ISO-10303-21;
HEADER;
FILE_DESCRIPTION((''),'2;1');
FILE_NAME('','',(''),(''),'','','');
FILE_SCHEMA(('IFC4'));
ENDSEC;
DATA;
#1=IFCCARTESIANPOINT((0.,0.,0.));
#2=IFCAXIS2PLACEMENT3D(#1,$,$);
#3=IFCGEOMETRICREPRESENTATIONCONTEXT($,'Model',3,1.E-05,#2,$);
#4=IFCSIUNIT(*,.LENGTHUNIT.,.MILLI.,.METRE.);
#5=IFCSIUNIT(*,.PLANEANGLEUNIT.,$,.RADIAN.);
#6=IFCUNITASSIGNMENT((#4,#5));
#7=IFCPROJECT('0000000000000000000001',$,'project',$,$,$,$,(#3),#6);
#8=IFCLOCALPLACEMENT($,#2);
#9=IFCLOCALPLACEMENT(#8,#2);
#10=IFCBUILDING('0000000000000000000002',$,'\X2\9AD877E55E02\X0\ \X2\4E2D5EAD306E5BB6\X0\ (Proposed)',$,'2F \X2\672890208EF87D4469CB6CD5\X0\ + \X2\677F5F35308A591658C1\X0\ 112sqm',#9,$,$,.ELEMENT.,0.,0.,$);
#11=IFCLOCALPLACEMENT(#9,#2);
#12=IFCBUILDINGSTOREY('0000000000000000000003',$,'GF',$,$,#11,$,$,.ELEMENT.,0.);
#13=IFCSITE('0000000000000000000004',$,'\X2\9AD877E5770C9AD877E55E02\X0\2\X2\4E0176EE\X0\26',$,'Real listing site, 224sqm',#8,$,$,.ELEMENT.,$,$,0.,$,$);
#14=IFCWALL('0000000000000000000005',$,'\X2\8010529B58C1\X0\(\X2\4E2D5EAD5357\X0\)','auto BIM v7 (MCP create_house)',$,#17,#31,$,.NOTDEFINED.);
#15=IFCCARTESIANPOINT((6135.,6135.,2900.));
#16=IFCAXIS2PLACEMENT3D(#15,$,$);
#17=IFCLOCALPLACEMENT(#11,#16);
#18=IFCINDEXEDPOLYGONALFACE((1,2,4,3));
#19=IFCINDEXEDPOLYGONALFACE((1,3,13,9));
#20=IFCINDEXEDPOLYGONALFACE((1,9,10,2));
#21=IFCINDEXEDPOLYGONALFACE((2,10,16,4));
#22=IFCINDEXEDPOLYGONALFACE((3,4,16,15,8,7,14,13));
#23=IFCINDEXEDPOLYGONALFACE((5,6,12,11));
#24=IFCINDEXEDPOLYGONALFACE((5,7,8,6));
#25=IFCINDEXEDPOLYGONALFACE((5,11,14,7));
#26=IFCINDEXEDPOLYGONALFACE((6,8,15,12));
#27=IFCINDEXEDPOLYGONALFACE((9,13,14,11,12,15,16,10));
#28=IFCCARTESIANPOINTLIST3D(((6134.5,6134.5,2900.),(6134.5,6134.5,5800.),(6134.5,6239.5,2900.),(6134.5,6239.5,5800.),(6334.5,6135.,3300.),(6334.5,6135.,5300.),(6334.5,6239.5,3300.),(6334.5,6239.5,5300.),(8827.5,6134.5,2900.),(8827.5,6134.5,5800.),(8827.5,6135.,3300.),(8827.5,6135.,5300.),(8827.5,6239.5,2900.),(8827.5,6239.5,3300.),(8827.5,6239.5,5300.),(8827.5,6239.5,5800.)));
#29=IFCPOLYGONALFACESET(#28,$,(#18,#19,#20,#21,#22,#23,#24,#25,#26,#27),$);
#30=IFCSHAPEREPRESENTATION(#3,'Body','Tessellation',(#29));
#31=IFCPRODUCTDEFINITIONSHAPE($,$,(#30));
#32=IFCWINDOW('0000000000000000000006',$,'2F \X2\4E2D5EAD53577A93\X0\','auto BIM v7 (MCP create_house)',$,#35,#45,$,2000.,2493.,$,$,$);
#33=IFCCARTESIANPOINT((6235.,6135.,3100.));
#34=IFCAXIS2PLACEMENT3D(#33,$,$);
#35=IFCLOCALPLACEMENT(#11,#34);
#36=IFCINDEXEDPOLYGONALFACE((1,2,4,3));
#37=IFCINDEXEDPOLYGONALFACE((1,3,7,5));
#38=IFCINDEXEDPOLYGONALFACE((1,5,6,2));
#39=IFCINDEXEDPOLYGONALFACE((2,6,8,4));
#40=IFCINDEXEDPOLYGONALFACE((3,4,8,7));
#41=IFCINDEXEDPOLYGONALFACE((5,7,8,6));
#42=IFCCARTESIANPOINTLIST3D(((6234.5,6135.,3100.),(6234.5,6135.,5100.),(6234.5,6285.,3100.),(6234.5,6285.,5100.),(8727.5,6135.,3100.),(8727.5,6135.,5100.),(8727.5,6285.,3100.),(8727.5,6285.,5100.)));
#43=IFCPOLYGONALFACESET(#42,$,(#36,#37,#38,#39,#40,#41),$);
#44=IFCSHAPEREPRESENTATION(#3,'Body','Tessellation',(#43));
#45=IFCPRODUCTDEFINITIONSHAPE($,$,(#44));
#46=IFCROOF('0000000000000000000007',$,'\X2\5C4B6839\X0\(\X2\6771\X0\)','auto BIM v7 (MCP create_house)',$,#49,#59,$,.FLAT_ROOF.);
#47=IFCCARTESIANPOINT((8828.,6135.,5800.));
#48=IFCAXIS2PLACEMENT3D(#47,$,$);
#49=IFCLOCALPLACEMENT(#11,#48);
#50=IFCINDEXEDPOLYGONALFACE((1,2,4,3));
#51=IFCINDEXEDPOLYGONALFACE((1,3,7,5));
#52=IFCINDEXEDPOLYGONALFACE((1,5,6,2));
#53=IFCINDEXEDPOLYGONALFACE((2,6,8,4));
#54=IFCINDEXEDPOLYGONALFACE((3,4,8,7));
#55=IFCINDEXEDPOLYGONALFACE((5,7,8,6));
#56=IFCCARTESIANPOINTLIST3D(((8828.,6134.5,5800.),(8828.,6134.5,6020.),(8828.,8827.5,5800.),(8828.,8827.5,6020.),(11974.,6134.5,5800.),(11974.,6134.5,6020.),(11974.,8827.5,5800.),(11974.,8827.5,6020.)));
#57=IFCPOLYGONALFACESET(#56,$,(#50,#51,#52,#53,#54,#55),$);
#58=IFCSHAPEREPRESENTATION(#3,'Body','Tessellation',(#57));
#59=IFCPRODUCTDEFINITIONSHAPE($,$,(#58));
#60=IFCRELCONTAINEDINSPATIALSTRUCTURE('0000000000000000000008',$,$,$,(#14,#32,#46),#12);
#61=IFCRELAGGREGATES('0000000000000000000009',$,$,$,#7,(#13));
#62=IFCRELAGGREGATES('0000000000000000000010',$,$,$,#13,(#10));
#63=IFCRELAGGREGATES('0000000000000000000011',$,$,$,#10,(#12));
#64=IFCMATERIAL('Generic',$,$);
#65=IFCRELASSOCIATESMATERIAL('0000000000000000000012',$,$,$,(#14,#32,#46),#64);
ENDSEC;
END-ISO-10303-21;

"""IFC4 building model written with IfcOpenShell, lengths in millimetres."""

from ifc_helpers import new_model, si_unit, frame, frame_2d, origin, place, context, project, spatial, rectangle, extrude, material, element, fill, save


model = new_model("IFC4")

# Units and contexts
model_context = context("Model", 3, precision=1e-05, world=origin())
ifc_project = project(units=[si_unit("LENGTHUNIT", "METRE", prefix="MILLI"), si_unit("PLANEANGLEUNIT", "RADIAN")], contexts=[model_context])

# Site, building, storey
site_placement = place(None, origin())
site = spatial("IfcSite", under=ifc_project, at=site_placement, Name="高知県高知市2丁目26", ObjectType="Real listing site, 224sqm", CompositionType="ELEMENT", RefElevation=0.0)
building_placement = place(site_placement, origin())
building = spatial("IfcBuilding", under=site, at=building_placement, Name="高知市 中庭の家 (Proposed)", ObjectType="2F 木造軸組構法 + 板張り外壁 112sqm", CompositionType="ELEMENT", ElevationOfRefHeight=0.0, ElevationOfTerrain=0.0)
storey_placement = place(building_placement, origin())
storey = spatial("IfcBuildingStorey", under=building, at=storey_placement, Name="GF", CompositionType="ELEMENT", Elevation=0.0)

# Shared definitions
ifc_material = material(Name="Generic")

# Wall, opening, window
wall_1_placement = place(storey_placement, frame((6135.0, 6135.0, 2900.0)))
wall_1 = element("IfcWall", 1, at=wall_1_placement, inside=storey, material=ifc_material, Name="耐力壁(中庭南)", Description="auto BIM v7 (MCP create_house)", PredefinedType="NOTDEFINED", context=model_context, shape_type="SweptSolid", body=[
    extrude(rectangle(XDim=2693.0, YDim=105.0, at=frame_2d((1346.0, 52.0))), frame((6135.0, 6135.0, 2900.0)), (0.0, 0.0, 1.0), 2900.0),
])
opening_1_placement = place(storey_placement, frame((6235.0, 6135.0, 3100.0)))
opening_1 = element("IfcOpeningElement", 2, at=opening_1_placement, cuts=wall_1, PredefinedType="NOTDEFINED", context=model_context, shape_type="SweptSolid", body=[
    extrude(rectangle(XDim=2493.0, YDim=150.0, at=frame_2d((1246.0, 75.0))), frame((6235.0, 6135.0, 3100.0)), (0.0, 0.0, 1.0), 2000.0),
])
window_1_placement = place(storey_placement, frame((6235.0, 6135.0, 3100.0)))
window_1 = element("IfcWindow", 3, at=window_1_placement, inside=storey, material=ifc_material, Name="2F 中庭南窓", Description="auto BIM v7 (MCP create_house)", OverallHeight=2000.0, OverallWidth=2493.0, context=model_context, shape_type="SweptSolid", body=[
    extrude(rectangle(XDim=2493.0, YDim=150.0, at=frame_2d((1246.0, 75.0))), frame((6235.0, 6135.0, 3100.0)), (0.0, 0.0, 1.0), 2000.0),
])
fill(opening_1, window_1)

# Roof
for number, where, name in (
    (4, (8828.0, 6135.0, 5800.0), "屋根(東)"),
):
    element("IfcRoof", number, at=place(storey_placement, frame(where)), inside=storey, material=ifc_material, Name=name, Description="auto BIM v7 (MCP create_house)", PredefinedType="FLAT_ROOF", context=model_context, shape_type="SweptSolid", body=[
        extrude(rectangle(XDim=3146.0, YDim=2693.0, at=frame_2d((1573.0, 1346.0))), frame((8828.0, 6135.0, 5800.0)), (0.0, 0.0, 1.0), 220.0),
    ])

save(model, "model.ifc")
